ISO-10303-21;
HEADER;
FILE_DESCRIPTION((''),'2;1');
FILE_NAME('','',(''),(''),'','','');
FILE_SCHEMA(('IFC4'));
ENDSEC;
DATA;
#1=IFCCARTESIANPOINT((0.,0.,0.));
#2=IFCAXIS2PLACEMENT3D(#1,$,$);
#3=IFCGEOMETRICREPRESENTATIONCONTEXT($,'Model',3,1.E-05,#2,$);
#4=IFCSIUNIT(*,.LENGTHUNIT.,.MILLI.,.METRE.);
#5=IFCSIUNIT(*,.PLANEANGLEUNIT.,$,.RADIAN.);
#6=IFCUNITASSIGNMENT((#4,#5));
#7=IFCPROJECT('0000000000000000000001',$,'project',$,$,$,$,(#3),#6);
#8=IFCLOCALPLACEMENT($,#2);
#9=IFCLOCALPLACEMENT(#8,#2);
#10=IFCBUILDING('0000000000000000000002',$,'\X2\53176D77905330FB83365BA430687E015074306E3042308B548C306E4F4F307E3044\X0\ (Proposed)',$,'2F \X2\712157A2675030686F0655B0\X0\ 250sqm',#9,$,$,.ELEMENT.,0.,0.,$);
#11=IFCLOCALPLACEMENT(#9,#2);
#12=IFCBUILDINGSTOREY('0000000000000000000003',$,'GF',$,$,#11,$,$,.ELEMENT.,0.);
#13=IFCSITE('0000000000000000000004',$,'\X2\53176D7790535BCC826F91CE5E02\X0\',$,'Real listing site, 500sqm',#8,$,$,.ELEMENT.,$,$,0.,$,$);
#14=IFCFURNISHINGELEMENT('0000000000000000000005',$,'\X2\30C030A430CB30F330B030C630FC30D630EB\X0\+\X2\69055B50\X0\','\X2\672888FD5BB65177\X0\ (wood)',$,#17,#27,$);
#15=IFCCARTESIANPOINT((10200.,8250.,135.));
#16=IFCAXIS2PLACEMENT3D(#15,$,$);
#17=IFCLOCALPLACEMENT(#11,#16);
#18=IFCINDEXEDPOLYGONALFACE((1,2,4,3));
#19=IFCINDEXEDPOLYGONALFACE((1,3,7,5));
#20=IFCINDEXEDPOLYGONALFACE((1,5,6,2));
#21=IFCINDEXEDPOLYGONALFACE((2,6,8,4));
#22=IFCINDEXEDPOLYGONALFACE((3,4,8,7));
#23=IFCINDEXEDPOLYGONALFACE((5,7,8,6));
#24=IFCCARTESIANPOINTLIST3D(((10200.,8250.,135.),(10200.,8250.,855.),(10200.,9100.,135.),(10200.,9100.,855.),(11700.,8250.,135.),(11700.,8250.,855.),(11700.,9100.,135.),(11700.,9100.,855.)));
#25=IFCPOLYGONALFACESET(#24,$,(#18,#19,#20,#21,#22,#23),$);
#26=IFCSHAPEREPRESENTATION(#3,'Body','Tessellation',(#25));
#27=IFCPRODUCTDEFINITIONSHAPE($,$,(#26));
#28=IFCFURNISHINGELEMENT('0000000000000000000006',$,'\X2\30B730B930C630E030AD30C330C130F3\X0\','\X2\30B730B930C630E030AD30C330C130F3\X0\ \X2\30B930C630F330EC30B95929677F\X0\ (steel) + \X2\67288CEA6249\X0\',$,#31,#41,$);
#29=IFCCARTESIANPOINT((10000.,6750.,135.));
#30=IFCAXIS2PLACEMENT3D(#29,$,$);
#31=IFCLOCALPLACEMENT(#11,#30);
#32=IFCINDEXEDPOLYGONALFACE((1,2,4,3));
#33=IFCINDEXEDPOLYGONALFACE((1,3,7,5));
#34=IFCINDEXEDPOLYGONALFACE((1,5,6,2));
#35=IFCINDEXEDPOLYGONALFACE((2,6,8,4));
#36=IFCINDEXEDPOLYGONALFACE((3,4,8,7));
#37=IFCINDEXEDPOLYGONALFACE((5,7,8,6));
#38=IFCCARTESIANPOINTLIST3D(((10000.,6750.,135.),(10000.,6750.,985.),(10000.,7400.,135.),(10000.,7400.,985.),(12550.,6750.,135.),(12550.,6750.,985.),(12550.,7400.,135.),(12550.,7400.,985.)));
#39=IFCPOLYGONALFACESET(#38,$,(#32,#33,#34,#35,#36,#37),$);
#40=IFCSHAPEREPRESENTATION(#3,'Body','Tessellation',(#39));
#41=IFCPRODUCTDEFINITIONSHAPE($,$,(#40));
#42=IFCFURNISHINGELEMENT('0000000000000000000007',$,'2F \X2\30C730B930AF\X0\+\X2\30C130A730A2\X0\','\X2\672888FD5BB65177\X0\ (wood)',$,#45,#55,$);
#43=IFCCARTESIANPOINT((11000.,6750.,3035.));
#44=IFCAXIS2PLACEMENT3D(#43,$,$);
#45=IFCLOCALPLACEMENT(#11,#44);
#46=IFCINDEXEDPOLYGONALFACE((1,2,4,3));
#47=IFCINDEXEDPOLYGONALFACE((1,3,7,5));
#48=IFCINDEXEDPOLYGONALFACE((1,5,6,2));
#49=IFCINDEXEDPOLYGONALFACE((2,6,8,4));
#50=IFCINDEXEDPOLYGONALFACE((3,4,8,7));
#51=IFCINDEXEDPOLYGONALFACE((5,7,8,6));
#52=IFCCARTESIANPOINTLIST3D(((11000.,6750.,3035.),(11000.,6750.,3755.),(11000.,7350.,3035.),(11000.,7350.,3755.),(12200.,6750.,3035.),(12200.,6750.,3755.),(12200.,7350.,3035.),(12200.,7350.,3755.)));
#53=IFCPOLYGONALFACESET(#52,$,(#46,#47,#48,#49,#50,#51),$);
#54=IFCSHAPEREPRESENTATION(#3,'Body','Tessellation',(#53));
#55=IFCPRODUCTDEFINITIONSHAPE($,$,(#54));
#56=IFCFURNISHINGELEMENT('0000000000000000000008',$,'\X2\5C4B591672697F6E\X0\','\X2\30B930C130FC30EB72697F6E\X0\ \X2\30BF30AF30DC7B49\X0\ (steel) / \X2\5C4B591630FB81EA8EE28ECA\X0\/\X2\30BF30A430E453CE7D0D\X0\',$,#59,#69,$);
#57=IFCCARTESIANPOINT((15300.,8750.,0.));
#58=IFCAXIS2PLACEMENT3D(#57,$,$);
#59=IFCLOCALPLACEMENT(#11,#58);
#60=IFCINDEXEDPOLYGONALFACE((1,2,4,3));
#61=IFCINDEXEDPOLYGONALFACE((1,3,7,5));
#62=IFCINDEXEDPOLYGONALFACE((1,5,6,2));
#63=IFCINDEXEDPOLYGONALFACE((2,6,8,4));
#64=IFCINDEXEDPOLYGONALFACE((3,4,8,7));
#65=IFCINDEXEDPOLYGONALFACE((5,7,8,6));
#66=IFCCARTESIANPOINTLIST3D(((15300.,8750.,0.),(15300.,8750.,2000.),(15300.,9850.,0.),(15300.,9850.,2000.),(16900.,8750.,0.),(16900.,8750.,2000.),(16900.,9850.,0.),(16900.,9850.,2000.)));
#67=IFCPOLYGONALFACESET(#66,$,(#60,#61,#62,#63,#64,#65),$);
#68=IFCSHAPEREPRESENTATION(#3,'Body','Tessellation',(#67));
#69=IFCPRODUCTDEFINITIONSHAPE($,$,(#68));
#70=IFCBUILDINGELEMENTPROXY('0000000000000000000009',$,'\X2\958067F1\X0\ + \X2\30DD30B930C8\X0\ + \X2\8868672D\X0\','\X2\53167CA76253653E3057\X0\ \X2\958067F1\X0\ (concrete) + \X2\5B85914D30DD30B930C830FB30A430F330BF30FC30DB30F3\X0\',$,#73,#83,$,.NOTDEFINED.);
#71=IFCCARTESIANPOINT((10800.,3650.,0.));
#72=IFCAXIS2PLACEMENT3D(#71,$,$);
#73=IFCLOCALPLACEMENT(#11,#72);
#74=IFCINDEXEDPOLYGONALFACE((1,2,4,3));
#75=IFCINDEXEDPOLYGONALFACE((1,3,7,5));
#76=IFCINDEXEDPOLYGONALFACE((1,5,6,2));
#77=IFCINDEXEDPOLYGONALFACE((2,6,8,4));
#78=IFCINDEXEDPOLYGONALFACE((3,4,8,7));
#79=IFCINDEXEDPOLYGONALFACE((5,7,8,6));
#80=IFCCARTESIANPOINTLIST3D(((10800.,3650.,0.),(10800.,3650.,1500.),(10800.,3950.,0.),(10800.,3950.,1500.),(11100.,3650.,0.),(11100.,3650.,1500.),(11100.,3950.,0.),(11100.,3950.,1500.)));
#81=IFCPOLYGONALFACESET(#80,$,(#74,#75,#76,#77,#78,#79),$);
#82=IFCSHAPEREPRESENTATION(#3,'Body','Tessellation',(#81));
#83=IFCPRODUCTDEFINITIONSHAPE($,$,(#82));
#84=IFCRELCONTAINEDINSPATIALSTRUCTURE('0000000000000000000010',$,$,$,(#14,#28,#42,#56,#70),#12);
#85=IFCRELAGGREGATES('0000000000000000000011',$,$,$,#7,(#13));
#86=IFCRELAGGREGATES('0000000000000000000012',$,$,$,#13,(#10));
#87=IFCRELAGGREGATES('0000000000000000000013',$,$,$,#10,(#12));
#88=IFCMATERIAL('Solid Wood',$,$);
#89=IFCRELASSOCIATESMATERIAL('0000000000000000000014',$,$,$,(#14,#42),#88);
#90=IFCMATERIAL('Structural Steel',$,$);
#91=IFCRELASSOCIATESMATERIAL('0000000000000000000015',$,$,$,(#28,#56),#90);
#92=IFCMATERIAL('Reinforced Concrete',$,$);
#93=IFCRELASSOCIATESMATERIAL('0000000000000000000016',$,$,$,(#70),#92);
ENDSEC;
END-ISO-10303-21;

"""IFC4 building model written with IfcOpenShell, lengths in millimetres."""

from ifc_helpers import new_model, si_unit, frame, frame_2d, origin, place, context, project, spatial, rectangle, extrude, material, element, save


model = new_model("IFC4")

# Units and contexts
model_context = context("Model", 3, precision=1e-05, world=origin())
ifc_project = project(units=[si_unit("LENGTHUNIT", "METRE", prefix="MILLI"), si_unit("PLANEANGLEUNIT", "RADIAN")], contexts=[model_context])

# Site, building, storey
site_placement = place(None, origin())
site = spatial("IfcSite", under=ifc_project, at=site_placement, Name="北海道富良野市", ObjectType="Real listing site, 500sqm", CompositionType="ELEMENT", RefElevation=0.0)
building_placement = place(site_placement, origin())
building = spatial("IfcBuilding", under=site, at=building_placement, Name="北海道・茶室と縁側のある和の住まい (Proposed)", ObjectType="2F 無垢材と漆喰 250sqm", CompositionType="ELEMENT", ElevationOfRefHeight=0.0, ElevationOfTerrain=0.0)
storey_placement = place(building_placement, origin())
storey = spatial("IfcBuildingStorey", under=building, at=storey_placement, Name="GF", CompositionType="ELEMENT", Elevation=0.0)

# Shared definitions
ifc_material_1 = material(Name="Solid Wood")

# Shared definitions
ifc_material_2 = material(Name="Reinforced Concrete")

# Shared definitions
ifc_material_3 = material(Name="Structural Steel")

# Furnishing elements
furnishing_1_placement = place(storey_placement, frame((10200.0, 8250.0, 135.0)))
element("IfcFurnishingElement", 1, at=furnishing_1_placement, inside=storey, material=ifc_material_1, Name="ダイニングテーブル+椅子", Description="木製家具 (wood)", context=model_context, shape_type="SweptSolid", body=[
    extrude(rectangle(XDim=1500.0, YDim=850.0, at=frame_2d((750.0, 425.0))), frame((10200.0, 8250.0, 135.0)), (0.0, 0.0, 1.0), 720.0),
])
furnishing_2_placement = place(storey_placement, frame((10000.0, 6750.0, 135.0)))
element("IfcFurnishingElement", 2, at=furnishing_2_placement, inside=storey, material=ifc_material_3, Name="システムキッチン", Description="システムキッチン ステンレス天板 (steel) + 木質扉", context=model_context, shape_type="SweptSolid", body=[
    extrude(rectangle(XDim=2550.0, YDim=650.0, at=frame_2d((1275.0, 325.0))), frame((10000.0, 6750.0, 135.0)), (0.0, 0.0, 1.0), 850.0),
])
furnishing_3_placement = place(storey_placement, frame((11000.0, 6750.0, 3035.0)))
element("IfcFurnishingElement", 3, at=furnishing_3_placement, inside=storey, material=ifc_material_1, Name="2F デスク+チェア", Description="木製家具 (wood)", context=model_context, shape_type="SweptSolid", body=[
    extrude(rectangle(XDim=1200.0, YDim=600.0, at=frame_2d((600.0, 300.0))), frame((11000.0, 6750.0, 3035.0)), (0.0, 0.0, 1.0), 720.0),
])
furnishing_4_placement = place(storey_placement, frame((15300.0, 8750.0, 0.0)))
element("IfcFurnishingElement", 4, at=furnishing_4_placement, inside=storey, material=ifc_material_3, Name="屋外物置", Description="スチール物置 タクボ等 (steel) / 屋外・自転車/タイヤ収納", context=model_context, shape_type="SweptSolid", body=[
    extrude(rectangle(XDim=1600.0, YDim=1100.0, at=frame_2d((800.0, 550.0))), frame((15300.0, 8750.0, 0.0)), (0.0, 0.0, 1.0), 2000.0),
])

# Building element proxy
proxy_placement = place(storey_placement, frame((10800.0, 3650.0, 0.0)))
element("IfcBuildingElementProxy", 5, at=proxy_placement, inside=storey, material=ifc_material_2, Name="門柱 + ポスト + 表札", Description="化粧打放し 門柱 (concrete) + 宅配ポスト・インターホン", PredefinedType="NOTDEFINED", context=model_context, shape_type="SweptSolid", body=[
    extrude(rectangle(XDim=300.0, YDim=300.0, at=frame_2d((150.0, 150.0))), frame((10800.0, 3650.0, 0.0)), (0.0, 0.0, 1.0), 1500.0),
])

save(model, "model.ifc")
